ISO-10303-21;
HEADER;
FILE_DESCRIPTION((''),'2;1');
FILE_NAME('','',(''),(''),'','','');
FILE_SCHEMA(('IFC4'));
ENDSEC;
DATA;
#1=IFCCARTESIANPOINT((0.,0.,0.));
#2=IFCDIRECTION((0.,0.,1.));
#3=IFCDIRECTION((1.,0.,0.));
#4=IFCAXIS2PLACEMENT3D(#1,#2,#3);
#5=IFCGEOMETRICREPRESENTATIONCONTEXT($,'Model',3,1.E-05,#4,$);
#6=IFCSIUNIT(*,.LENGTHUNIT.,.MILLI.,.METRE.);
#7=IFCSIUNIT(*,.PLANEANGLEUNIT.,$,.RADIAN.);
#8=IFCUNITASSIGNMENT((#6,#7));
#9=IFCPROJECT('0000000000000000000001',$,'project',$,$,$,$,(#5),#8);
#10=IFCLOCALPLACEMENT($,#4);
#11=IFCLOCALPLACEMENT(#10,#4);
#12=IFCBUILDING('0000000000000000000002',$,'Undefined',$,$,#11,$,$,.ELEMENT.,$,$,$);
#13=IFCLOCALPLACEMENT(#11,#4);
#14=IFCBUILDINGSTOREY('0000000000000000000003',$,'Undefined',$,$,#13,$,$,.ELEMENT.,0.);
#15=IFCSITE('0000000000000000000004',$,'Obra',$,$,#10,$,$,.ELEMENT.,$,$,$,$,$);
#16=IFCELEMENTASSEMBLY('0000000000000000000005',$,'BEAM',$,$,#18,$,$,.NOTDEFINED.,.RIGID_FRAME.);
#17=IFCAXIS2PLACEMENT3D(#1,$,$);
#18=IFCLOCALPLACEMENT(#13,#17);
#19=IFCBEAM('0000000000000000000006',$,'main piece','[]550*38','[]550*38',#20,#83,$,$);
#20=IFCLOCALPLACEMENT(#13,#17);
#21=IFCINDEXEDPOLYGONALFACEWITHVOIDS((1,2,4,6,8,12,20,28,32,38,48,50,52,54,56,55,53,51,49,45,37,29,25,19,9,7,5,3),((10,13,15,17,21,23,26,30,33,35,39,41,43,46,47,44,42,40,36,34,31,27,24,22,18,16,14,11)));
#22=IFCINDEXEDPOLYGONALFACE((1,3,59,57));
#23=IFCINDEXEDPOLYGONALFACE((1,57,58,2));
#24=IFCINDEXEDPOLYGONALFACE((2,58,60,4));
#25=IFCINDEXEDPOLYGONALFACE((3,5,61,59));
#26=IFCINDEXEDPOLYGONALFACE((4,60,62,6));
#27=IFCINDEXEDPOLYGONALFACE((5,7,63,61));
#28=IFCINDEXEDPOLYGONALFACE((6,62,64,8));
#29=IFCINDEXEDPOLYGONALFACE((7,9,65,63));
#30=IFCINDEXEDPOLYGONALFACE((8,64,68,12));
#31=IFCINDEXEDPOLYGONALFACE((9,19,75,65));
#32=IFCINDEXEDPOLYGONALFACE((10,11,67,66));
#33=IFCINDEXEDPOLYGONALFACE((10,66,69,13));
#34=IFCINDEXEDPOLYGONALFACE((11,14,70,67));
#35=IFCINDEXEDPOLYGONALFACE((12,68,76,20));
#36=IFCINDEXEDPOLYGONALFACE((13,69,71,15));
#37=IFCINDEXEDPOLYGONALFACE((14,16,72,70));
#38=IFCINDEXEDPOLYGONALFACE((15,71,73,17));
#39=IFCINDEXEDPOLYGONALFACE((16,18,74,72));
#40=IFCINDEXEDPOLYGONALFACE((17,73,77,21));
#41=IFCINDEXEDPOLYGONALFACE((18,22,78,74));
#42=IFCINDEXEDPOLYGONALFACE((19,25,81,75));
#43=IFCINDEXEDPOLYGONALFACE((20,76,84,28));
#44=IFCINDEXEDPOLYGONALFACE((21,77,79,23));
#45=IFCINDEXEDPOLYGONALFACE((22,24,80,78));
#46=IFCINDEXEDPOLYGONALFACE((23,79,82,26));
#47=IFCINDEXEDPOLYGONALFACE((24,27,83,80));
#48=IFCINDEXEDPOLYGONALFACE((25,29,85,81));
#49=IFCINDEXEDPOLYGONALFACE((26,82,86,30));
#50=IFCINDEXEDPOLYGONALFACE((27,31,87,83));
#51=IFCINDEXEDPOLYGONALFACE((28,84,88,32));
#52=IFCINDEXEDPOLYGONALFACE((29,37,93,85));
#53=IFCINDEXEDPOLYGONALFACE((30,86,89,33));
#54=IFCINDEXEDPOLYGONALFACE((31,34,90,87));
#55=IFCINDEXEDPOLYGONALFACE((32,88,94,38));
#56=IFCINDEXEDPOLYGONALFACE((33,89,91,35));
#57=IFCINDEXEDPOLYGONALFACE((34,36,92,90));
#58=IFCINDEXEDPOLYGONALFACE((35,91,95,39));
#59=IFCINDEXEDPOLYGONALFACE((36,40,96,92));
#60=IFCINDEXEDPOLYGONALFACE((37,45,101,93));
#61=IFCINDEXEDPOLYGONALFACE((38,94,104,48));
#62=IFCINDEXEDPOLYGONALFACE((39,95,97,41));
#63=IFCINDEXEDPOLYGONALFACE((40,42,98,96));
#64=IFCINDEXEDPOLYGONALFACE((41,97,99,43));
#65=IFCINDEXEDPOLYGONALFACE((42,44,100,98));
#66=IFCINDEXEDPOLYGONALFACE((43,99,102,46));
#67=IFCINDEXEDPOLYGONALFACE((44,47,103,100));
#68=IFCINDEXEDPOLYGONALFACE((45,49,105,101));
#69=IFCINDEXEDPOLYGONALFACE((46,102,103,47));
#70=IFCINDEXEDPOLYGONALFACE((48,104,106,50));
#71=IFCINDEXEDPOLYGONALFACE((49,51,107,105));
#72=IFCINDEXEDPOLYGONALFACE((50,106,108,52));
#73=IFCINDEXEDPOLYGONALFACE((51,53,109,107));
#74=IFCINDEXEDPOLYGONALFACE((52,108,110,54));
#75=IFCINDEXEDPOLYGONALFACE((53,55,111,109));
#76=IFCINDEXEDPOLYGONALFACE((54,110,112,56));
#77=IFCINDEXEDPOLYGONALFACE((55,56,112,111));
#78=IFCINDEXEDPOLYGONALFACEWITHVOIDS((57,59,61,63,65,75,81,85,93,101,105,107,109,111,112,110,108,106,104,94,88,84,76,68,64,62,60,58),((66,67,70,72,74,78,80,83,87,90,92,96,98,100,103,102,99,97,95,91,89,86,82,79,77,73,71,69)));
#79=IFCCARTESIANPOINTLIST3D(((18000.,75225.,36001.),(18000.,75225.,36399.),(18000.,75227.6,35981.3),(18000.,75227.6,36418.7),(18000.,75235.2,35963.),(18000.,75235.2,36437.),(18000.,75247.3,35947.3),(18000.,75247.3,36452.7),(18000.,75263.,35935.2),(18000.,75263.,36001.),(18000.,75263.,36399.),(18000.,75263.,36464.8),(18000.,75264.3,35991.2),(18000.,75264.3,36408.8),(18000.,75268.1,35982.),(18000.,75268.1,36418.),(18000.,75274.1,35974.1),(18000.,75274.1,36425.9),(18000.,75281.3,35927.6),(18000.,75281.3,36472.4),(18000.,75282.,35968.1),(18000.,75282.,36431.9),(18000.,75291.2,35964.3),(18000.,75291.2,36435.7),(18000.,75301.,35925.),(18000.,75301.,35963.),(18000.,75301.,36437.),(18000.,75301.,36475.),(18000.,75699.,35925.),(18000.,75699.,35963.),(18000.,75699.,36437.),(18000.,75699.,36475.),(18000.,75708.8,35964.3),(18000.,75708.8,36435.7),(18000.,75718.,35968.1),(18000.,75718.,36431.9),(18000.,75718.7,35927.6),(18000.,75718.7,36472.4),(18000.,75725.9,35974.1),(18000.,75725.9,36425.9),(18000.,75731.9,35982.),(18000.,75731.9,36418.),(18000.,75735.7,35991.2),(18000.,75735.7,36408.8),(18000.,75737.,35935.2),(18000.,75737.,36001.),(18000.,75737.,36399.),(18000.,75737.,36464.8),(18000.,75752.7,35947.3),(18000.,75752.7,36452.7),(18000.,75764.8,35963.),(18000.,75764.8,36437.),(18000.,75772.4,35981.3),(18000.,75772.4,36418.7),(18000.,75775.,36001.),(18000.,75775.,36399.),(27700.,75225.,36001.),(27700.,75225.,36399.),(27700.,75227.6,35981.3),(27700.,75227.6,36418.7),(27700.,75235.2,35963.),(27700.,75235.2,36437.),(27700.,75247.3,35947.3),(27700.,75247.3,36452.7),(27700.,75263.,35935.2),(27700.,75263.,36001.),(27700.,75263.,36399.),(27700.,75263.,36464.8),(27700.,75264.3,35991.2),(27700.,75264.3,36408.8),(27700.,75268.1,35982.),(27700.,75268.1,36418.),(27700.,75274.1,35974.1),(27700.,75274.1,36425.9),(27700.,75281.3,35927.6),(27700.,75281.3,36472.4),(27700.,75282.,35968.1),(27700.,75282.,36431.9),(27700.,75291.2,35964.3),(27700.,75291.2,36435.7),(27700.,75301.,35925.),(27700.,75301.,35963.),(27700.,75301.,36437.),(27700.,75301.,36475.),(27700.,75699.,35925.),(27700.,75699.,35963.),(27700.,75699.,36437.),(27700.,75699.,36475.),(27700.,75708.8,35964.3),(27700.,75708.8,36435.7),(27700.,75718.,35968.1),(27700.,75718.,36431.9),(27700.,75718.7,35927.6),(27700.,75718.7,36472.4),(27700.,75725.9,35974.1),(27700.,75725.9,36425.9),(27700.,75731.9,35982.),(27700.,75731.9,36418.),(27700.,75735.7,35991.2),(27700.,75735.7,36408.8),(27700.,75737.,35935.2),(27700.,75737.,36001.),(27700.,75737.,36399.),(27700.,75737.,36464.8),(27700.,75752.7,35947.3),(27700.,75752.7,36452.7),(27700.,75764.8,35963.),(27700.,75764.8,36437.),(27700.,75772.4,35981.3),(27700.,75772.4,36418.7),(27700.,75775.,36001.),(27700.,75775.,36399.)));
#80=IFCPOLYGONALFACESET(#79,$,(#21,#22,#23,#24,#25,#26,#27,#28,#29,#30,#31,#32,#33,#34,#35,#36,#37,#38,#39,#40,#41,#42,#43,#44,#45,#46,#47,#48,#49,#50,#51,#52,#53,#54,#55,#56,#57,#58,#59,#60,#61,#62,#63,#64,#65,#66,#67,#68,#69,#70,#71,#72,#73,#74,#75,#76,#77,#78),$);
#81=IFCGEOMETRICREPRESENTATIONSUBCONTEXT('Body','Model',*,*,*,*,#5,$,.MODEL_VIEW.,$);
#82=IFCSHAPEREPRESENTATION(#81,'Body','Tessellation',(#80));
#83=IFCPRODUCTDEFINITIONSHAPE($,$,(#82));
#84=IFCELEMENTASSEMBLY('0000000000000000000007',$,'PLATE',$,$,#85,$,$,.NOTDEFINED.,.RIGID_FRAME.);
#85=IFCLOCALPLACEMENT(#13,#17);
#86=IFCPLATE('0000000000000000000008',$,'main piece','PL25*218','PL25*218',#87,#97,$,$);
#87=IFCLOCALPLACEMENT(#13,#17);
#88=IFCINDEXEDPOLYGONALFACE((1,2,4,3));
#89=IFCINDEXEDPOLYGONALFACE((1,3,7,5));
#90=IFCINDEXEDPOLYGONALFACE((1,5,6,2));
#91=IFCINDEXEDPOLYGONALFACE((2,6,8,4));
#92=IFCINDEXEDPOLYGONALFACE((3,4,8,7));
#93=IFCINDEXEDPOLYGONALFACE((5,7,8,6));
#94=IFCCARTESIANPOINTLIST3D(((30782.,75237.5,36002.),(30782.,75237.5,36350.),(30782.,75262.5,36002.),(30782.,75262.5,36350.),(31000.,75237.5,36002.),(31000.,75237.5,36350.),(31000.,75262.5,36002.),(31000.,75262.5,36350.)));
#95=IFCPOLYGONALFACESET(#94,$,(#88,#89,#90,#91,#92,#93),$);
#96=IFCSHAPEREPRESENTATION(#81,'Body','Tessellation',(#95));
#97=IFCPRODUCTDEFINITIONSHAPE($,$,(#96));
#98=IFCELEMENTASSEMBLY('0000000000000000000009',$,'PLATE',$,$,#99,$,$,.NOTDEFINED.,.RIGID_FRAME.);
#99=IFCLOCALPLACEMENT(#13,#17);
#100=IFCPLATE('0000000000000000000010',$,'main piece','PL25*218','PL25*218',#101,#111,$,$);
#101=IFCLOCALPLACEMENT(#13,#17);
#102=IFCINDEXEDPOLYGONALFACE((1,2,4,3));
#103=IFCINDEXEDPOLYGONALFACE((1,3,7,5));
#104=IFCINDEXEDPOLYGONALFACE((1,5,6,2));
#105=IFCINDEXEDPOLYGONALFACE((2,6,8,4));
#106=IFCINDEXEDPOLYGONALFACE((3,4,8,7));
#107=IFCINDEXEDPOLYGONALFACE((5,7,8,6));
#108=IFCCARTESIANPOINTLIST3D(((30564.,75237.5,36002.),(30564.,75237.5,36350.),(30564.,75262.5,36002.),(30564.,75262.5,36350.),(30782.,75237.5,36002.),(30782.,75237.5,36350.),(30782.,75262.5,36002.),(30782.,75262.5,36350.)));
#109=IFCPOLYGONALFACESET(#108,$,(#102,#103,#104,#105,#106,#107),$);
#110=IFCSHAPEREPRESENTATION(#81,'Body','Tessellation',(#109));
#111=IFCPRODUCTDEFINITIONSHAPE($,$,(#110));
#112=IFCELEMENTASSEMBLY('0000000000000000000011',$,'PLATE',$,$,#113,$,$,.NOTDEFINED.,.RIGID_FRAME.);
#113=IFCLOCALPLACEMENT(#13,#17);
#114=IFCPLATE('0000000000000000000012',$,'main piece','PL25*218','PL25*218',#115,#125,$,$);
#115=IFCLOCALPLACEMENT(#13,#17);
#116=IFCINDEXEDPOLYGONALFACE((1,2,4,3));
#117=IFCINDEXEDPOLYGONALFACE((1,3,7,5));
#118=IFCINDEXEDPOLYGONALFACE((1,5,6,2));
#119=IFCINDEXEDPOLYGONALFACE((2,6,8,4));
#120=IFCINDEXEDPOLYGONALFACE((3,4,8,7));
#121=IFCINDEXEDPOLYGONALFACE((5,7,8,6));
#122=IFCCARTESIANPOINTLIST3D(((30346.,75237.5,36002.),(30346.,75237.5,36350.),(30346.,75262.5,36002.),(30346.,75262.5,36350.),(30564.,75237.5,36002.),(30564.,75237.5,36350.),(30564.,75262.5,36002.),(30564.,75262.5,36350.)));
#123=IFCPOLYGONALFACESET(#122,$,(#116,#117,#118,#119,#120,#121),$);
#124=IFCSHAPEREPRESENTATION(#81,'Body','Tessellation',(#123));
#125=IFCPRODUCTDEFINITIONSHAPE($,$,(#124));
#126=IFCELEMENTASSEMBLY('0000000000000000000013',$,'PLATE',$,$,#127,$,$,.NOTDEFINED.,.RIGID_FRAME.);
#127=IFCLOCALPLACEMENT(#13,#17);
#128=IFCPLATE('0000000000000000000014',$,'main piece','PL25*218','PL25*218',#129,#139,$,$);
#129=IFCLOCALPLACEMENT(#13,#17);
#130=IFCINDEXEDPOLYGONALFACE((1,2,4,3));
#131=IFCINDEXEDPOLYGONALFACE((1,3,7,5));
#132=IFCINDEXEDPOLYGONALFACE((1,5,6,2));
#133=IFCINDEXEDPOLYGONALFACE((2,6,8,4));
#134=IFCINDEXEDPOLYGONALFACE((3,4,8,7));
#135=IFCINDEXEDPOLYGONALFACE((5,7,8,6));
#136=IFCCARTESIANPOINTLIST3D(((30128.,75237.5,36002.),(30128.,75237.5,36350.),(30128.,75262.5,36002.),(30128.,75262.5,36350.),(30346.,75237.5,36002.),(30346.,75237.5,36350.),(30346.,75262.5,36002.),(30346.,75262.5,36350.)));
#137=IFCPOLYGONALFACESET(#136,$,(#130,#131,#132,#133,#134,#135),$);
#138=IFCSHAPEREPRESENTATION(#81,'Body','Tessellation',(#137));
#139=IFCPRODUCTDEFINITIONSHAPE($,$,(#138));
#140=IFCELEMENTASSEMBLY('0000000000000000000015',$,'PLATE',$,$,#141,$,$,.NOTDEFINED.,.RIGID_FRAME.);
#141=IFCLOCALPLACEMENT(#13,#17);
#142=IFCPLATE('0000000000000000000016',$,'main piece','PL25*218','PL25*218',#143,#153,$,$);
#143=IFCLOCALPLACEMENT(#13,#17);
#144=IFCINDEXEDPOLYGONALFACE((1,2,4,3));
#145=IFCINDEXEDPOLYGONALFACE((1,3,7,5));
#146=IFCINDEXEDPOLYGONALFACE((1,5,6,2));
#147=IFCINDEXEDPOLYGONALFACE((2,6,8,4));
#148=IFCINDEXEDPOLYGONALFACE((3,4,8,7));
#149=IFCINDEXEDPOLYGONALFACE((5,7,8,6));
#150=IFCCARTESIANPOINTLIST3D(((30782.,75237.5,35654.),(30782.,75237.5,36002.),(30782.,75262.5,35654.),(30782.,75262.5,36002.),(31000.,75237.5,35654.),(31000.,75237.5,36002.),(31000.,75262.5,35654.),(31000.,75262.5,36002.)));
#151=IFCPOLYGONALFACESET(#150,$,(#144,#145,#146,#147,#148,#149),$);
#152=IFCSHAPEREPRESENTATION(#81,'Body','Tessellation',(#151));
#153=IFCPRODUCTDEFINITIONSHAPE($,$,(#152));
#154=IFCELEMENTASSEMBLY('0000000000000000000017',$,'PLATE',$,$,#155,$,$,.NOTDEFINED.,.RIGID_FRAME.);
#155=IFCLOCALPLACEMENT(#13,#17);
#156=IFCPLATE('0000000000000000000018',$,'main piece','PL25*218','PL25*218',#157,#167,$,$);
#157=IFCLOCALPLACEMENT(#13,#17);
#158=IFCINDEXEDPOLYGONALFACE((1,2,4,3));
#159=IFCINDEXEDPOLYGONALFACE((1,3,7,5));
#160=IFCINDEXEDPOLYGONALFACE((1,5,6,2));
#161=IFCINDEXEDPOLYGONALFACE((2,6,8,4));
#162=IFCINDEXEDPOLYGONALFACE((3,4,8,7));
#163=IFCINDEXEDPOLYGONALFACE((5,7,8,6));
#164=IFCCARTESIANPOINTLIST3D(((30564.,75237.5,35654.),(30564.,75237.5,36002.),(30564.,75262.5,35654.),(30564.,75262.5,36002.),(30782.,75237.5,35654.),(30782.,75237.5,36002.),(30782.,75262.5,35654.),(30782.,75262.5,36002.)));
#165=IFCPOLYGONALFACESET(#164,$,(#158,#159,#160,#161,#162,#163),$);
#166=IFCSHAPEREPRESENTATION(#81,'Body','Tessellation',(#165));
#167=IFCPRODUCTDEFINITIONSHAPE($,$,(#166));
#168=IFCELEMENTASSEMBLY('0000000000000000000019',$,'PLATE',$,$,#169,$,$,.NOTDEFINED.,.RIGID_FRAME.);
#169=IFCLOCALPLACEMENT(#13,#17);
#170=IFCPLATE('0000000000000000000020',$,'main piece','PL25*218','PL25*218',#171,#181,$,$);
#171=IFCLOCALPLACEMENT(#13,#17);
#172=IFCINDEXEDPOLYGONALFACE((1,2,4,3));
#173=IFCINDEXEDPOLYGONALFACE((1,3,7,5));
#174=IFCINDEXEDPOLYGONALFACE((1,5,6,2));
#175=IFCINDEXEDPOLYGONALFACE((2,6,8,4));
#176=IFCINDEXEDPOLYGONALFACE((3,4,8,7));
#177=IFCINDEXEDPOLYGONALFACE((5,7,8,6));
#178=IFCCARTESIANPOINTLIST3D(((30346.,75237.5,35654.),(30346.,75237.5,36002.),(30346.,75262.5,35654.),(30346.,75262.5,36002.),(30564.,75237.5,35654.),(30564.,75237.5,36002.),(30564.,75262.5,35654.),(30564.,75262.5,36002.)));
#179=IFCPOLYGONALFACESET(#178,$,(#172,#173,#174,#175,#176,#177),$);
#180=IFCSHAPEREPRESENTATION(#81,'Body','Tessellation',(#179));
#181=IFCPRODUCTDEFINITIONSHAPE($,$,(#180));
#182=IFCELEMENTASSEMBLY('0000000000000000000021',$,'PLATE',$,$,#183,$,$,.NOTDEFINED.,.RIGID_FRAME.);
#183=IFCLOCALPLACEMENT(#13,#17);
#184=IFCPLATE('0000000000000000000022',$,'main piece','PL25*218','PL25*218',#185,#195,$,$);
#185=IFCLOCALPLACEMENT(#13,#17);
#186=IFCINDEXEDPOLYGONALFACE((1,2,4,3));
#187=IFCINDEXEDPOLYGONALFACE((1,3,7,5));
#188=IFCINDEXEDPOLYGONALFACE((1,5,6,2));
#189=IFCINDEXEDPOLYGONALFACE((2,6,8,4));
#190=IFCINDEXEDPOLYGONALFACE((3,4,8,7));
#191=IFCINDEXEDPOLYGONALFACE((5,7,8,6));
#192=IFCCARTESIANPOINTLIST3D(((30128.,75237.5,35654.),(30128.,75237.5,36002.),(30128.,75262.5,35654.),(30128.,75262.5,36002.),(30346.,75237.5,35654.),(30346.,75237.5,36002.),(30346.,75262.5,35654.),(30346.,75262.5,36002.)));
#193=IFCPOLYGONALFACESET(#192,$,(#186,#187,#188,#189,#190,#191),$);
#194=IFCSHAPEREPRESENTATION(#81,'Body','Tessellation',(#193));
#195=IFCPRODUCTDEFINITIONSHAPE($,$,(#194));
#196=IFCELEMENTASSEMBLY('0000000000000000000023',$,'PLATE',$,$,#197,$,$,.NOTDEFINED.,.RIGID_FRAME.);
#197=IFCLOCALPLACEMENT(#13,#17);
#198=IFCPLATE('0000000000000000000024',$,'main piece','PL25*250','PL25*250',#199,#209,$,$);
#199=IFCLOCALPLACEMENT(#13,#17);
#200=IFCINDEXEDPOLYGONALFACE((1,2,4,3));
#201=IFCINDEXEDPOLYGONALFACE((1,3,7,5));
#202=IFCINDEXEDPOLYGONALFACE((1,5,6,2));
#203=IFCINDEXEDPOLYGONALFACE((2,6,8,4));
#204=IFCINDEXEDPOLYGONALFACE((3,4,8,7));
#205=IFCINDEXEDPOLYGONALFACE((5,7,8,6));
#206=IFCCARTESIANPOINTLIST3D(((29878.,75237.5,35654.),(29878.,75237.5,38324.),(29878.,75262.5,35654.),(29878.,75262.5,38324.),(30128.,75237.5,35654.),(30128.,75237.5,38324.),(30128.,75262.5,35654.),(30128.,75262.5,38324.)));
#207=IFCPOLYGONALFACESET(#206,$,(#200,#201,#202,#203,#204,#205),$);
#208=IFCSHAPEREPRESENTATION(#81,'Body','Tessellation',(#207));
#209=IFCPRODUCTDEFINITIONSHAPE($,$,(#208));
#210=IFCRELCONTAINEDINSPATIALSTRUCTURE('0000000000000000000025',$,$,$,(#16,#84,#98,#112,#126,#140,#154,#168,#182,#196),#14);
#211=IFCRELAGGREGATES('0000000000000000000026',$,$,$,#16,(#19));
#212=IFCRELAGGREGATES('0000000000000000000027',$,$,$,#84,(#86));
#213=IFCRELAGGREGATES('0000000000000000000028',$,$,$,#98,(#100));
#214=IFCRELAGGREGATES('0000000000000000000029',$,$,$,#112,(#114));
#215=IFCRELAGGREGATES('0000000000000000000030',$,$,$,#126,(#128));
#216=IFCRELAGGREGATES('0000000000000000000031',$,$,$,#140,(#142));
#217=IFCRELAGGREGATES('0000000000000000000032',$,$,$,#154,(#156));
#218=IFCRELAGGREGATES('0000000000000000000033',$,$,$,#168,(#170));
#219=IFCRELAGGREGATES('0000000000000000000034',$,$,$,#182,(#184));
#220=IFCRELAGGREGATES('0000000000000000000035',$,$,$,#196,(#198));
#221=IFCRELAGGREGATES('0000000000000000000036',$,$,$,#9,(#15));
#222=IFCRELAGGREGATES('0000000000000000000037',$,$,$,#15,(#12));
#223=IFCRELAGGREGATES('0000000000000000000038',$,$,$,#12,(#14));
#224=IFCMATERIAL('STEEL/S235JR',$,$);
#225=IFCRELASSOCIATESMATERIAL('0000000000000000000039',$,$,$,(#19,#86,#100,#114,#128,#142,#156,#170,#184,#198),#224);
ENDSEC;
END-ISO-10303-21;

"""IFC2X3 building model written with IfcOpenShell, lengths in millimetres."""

from ifc_helpers import new_model, si_unit, frame, origin_with_axes, origin_2d_with_axis, place, context, subcontext, project, spatial, polyline, hollow_rectangle, outline, extrude, material, element, aggregate, save


model = new_model("IFC2X3")

# Units and contexts
model_context = context("Model", 3, precision=1e-05, world=origin_with_axes())
body_context = subcontext(model_context, "Body", "Model", "MODEL_VIEW")
ifc_project = project(units=[si_unit("LENGTHUNIT", "METRE", prefix="MILLI"), si_unit("PLANEANGLEUNIT", "RADIAN")], contexts=[model_context])

# Site, building, storey
site_placement = place(None, origin_with_axes())
site = spatial("IfcSite", under=ifc_project, at=site_placement, Name="Obra", CompositionType="ELEMENT")
building_placement = place(site_placement, origin_with_axes())
building = spatial("IfcBuilding", under=site, at=building_placement, Name="Undefined", CompositionType="ELEMENT")
storey_placement = place(building_placement, origin_with_axes())
storey = spatial("IfcBuildingStorey", under=building, at=storey_placement, Name="Undefined", CompositionType="ELEMENT", Elevation=0.0)

# Element assembly, beam
assembly_1_placement = place(storey_placement, origin_with_axes())
assembly_1 = element("IfcElementAssembly", 1, at=assembly_1_placement, inside=storey, Name="BEAM", AssemblyPlace="NOTDEFINED", PredefinedType="RIGID_FRAME")
ifc_material = material(Name="STEEL/S235JR")
beam_placement = place(assembly_1_placement, frame((27700.0, 75500.0, 36200.0), z_axis=(0.0, 0.0, 1.0), x_axis=(-1.0, 0.0, 0.0)))
beam = element("IfcBeam", 2, at=beam_placement, material=ifc_material, Name="main piece", Description="[]550*38", ObjectType="[]550*38", context=body_context, shape_type="SweptSolid", body=[
    extrude(hollow_rectangle(XDim=550.0, YDim=550.0, WallThickness=38.0, InnerFilletRadius=38.0, OuterFilletRadius=76.0, at=origin_2d_with_axis()), frame((9700.0, 0.0, 0.0), z_axis=(-1.0, 0.0, 0.0), x_axis=(0.0, -1.0, 0.0)), (0.0, 0.0, 1.0), 9700.0),
])
aggregate(assembly_1, [beam])

# Element assemblies, plates
assembly_2_placement = place(storey_placement, origin_with_axes())
assembly_2 = element("IfcElementAssembly", 3, at=assembly_2_placement, inside=storey, Name="PLATE", AssemblyPlace="NOTDEFINED", PredefinedType="RIGID_FRAME")
plate_1_placement = place(assembly_2_placement, frame((30782.0, 75250.0, 36002.0), z_axis=(0.0, -1.0, 0.0), x_axis=(1.0, 0.0, 0.0)))
plate_1 = element("IfcPlate", 4, at=plate_1_placement, material=ifc_material, Name="main piece", Description="PL25*218", ObjectType="PL25*218", context=body_context, shape_type="SweptSolid", body=[
    extrude(outline(polyline([(0.0, 0.0), (218.0, 0.0), (218.0, 348.0), (0.0, 348.0), (0.0, 0.0)])), frame((0.0, 0.0, -12.5), z_axis=(0.0, 0.0, 1.0), x_axis=(1.0, 0.0, 0.0)), (0.0, 0.0, 1.0), 25.0),
])
aggregate(assembly_2, [plate_1])
assembly_3_placement = place(storey_placement, origin_with_axes())
assembly_3 = element("IfcElementAssembly", 5, at=assembly_3_placement, inside=storey, Name="PLATE", AssemblyPlace="NOTDEFINED", PredefinedType="RIGID_FRAME")
plate_2_placement = place(assembly_3_placement, frame((30564.0, 75250.0, 36002.0), z_axis=(0.0, -1.0, 0.0), x_axis=(1.0, 0.0, 0.0)))
plate_2 = element("IfcPlate", 6, at=plate_2_placement, material=ifc_material, Name="main piece", Description="PL25*218", ObjectType="PL25*218", context=body_context, shape_type="SweptSolid", body=[
    extrude(outline(polyline([(0.0, 0.0), (218.0, 0.0), (218.0, 348.0), (0.0, 348.0), (0.0, 0.0)])), frame((0.0, 0.0, -12.5), z_axis=(0.0, 0.0, 1.0), x_axis=(1.0, 0.0, 0.0)), (0.0, 0.0, 1.0), 25.0),
])
aggregate(assembly_3, [plate_2])
assembly_4_placement = place(storey_placement, origin_with_axes())
assembly_4 = element("IfcElementAssembly", 7, at=assembly_4_placement, inside=storey, Name="PLATE", AssemblyPlace="NOTDEFINED", PredefinedType="RIGID_FRAME")
plate_3_placement = place(assembly_4_placement, frame((30346.0, 75250.0, 36002.0), z_axis=(0.0, -1.0, 0.0), x_axis=(1.0, 0.0, 0.0)))
plate_3 = element("IfcPlate", 8, at=plate_3_placement, material=ifc_material, Name="main piece", Description="PL25*218", ObjectType="PL25*218", context=body_context, shape_type="SweptSolid", body=[
    extrude(outline(polyline([(0.0, 0.0), (218.0, 0.0), (218.0, 348.0), (0.0, 348.0), (0.0, 0.0)])), frame((0.0, 0.0, -12.5), z_axis=(0.0, 0.0, 1.0), x_axis=(1.0, 0.0, 0.0)), (0.0, 0.0, 1.0), 25.0),
])
aggregate(assembly_4, [plate_3])
assembly_5_placement = place(storey_placement, origin_with_axes())
assembly_5 = element("IfcElementAssembly", 9, at=assembly_5_placement, inside=storey, Name="PLATE", AssemblyPlace="NOTDEFINED", PredefinedType="RIGID_FRAME")
plate_4_placement = place(assembly_5_placement, frame((30128.0, 75250.0, 36002.0), z_axis=(0.0, -1.0, 0.0), x_axis=(1.0, 0.0, 0.0)))
plate_4 = element("IfcPlate", 10, at=plate_4_placement, material=ifc_material, Name="main piece", Description="PL25*218", ObjectType="PL25*218", context=body_context, shape_type="SweptSolid", body=[
    extrude(outline(polyline([(0.0, 0.0), (218.0, 0.0), (218.0, 348.0), (0.0, 348.0), (0.0, 0.0)])), frame((0.0, 0.0, -12.5), z_axis=(0.0, 0.0, 1.0), x_axis=(1.0, 0.0, 0.0)), (0.0, 0.0, 1.0), 25.0),
])
aggregate(assembly_5, [plate_4])
assembly_6_placement = place(storey_placement, origin_with_axes())
assembly_6 = element("IfcElementAssembly", 11, at=assembly_6_placement, inside=storey, Name="PLATE", AssemblyPlace="NOTDEFINED", PredefinedType="RIGID_FRAME")
plate_5_placement = place(assembly_6_placement, frame((30782.0, 75250.0, 35654.0), z_axis=(0.0, -1.0, 0.0), x_axis=(1.0, 0.0, 0.0)))
plate_5 = element("IfcPlate", 12, at=plate_5_placement, material=ifc_material, Name="main piece", Description="PL25*218", ObjectType="PL25*218", context=body_context, shape_type="SweptSolid", body=[
    extrude(outline(polyline([(0.0, 0.0), (218.0, 0.0), (218.0, 348.0), (0.0, 348.0), (0.0, 0.0)])), frame((0.0, 0.0, -12.5), z_axis=(0.0, 0.0, 1.0), x_axis=(1.0, 0.0, 0.0)), (0.0, 0.0, 1.0), 25.0),
])
aggregate(assembly_6, [plate_5])
assembly_7_placement = place(storey_placement, origin_with_axes())
assembly_7 = element("IfcElementAssembly", 13, at=assembly_7_placement, inside=storey, Name="PLATE", AssemblyPlace="NOTDEFINED", PredefinedType="RIGID_FRAME")
plate_6_placement = place(assembly_7_placement, frame((30564.0, 75250.0, 35654.0), z_axis=(0.0, -1.0, 0.0), x_axis=(1.0, 0.0, 0.0)))
plate_6 = element("IfcPlate", 14, at=plate_6_placement, material=ifc_material, Name="main piece", Description="PL25*218", ObjectType="PL25*218", context=body_context, shape_type="SweptSolid", body=[
    extrude(outline(polyline([(0.0, 0.0), (218.0, 0.0), (218.0, 348.0), (0.0, 348.0), (0.0, 0.0)])), frame((0.0, 0.0, -12.5), z_axis=(0.0, 0.0, 1.0), x_axis=(1.0, 0.0, 0.0)), (0.0, 0.0, 1.0), 25.0),
])
aggregate(assembly_7, [plate_6])
assembly_8_placement = place(storey_placement, origin_with_axes())
assembly_8 = element("IfcElementAssembly", 15, at=assembly_8_placement, inside=storey, Name="PLATE", AssemblyPlace="NOTDEFINED", PredefinedType="RIGID_FRAME")
plate_7_placement = place(assembly_8_placement, frame((30346.0, 75250.0, 35654.0), z_axis=(0.0, -1.0, 0.0), x_axis=(1.0, 0.0, 0.0)))
plate_7 = element("IfcPlate", 16, at=plate_7_placement, material=ifc_material, Name="main piece", Description="PL25*218", ObjectType="PL25*218", context=body_context, shape_type="SweptSolid", body=[
    extrude(outline(polyline([(0.0, 0.0), (218.0, 0.0), (218.0, 348.0), (0.0, 348.0), (0.0, 0.0)])), frame((0.0, 0.0, -12.5), z_axis=(0.0, 0.0, 1.0), x_axis=(1.0, 0.0, 0.0)), (0.0, 0.0, 1.0), 25.0),
])
aggregate(assembly_8, [plate_7])
assembly_9_placement = place(storey_placement, origin_with_axes())
assembly_9 = element("IfcElementAssembly", 17, at=assembly_9_placement, inside=storey, Name="PLATE", AssemblyPlace="NOTDEFINED", PredefinedType="RIGID_FRAME")
plate_8_placement = place(assembly_9_placement, frame((30128.0, 75250.0, 35654.0), z_axis=(0.0, -1.0, 0.0), x_axis=(1.0, 0.0, 0.0)))
plate_8 = element("IfcPlate", 18, at=plate_8_placement, material=ifc_material, Name="main piece", Description="PL25*218", ObjectType="PL25*218", context=body_context, shape_type="SweptSolid", body=[
    extrude(outline(polyline([(0.0, 0.0), (218.0, 0.0), (218.0, 348.0), (0.0, 348.0), (0.0, 0.0)])), frame((0.0, 0.0, -12.5), z_axis=(0.0, 0.0, 1.0), x_axis=(1.0, 0.0, 0.0)), (0.0, 0.0, 1.0), 25.0),
])
aggregate(assembly_9, [plate_8])
assembly_10_placement = place(storey_placement, origin_with_axes())
assembly_10 = element("IfcElementAssembly", 19, at=assembly_10_placement, inside=storey, Name="PLATE", AssemblyPlace="NOTDEFINED", PredefinedType="RIGID_FRAME")
plate_9_placement = place(assembly_10_placement, frame((29878.0, 75250.0, 35654.0), z_axis=(0.0, -1.0, 0.0), x_axis=(1.0, 0.0, 0.0)))
plate_9 = element("IfcPlate", 20, at=plate_9_placement, material=ifc_material, Name="main piece", Description="PL25*250", ObjectType="PL25*250", context=body_context, shape_type="SweptSolid", body=[
    extrude(outline(polyline([(0.0, 0.0), (250.0, 0.0), (250.0, 2670.0), (0.0, 2670.0), (0.0, 0.0)])), frame((0.0, 0.0, -12.5), z_axis=(0.0, 0.0, 1.0), x_axis=(1.0, 0.0, 0.0)), (0.0, 0.0, 1.0), 25.0),
])
aggregate(assembly_10, [plate_9])

save(model, "model.ifc")
